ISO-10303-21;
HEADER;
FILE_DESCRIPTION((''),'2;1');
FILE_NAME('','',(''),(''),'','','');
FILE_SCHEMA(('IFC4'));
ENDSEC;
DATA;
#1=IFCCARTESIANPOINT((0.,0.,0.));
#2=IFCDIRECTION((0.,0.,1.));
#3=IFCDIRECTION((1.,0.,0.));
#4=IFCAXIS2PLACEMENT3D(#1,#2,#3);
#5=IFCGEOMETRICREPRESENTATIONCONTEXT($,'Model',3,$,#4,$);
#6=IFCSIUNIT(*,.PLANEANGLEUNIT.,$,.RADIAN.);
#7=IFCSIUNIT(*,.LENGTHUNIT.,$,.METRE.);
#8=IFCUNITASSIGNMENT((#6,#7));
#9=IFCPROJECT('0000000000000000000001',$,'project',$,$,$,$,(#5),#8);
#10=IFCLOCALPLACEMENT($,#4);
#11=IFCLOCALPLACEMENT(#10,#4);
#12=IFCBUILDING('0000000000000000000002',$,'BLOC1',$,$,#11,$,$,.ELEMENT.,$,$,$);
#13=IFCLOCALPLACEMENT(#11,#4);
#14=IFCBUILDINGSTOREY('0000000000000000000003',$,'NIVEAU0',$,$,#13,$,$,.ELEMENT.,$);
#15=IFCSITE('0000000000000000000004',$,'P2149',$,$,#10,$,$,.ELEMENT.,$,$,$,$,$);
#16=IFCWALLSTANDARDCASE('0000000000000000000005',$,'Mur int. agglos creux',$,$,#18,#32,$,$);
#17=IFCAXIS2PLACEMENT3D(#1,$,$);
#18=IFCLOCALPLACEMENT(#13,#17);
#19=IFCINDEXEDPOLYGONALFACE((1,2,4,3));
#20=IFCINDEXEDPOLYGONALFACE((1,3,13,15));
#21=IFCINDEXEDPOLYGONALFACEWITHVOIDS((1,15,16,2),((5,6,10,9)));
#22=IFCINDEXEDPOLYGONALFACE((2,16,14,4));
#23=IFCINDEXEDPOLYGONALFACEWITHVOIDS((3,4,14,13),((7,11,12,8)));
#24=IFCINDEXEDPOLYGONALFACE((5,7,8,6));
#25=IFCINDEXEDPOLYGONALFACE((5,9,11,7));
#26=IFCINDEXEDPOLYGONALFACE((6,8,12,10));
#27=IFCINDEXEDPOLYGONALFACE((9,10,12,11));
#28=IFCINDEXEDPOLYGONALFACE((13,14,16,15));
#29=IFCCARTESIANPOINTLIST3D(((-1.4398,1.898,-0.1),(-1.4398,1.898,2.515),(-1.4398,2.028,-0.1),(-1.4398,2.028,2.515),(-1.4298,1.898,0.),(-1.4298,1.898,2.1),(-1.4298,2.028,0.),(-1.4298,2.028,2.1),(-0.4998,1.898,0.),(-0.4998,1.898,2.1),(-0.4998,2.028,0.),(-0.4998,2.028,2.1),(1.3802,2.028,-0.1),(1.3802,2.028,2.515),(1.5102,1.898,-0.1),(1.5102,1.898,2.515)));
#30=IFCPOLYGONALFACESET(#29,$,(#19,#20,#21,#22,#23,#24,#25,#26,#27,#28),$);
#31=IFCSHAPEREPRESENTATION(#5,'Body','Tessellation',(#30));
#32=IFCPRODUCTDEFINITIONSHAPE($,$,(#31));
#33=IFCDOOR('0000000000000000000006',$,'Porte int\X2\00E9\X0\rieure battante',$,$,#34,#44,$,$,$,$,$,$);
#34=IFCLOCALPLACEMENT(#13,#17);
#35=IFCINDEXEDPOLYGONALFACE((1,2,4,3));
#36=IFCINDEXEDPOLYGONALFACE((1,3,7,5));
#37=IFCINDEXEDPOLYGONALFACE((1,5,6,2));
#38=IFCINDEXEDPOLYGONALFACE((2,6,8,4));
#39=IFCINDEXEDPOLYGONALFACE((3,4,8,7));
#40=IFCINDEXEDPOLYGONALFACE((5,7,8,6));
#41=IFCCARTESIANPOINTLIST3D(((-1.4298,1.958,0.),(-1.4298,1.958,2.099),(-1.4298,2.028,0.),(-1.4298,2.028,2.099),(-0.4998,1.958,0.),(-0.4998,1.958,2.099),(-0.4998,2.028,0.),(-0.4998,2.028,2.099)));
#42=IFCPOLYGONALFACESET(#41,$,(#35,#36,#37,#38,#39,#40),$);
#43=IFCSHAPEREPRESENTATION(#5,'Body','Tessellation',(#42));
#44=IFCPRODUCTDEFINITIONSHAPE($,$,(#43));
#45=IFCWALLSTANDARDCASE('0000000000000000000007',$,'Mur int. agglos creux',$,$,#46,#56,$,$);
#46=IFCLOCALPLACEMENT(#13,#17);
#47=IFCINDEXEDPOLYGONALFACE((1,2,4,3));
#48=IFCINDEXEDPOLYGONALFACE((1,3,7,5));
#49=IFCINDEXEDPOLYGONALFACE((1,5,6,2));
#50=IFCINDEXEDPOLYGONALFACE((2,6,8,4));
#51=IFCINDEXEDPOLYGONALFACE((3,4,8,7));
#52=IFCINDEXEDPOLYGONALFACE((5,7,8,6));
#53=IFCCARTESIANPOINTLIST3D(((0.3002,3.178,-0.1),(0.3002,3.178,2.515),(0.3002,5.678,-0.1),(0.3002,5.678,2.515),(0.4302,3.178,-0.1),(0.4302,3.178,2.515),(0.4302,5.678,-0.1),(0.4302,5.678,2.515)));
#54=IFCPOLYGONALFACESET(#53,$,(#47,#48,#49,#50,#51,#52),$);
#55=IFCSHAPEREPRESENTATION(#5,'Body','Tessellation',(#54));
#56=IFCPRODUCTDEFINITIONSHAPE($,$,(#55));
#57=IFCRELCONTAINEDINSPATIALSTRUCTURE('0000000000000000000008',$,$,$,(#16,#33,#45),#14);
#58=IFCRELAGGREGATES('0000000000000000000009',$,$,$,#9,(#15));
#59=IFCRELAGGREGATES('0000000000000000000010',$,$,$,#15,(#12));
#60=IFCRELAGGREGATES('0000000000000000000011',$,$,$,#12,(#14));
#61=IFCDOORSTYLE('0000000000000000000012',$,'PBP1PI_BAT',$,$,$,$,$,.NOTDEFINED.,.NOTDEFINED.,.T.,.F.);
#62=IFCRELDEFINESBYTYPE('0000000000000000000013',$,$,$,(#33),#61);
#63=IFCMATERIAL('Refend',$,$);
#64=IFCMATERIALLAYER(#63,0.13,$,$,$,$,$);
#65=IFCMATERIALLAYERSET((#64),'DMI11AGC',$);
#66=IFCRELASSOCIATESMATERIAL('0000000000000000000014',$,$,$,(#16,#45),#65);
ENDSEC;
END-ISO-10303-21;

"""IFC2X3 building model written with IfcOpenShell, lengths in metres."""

from ifc_helpers import new_model, si_unit, point, frame, frame_2d, origin_with_axes, place, context, project, spatial, line_curve, trimmed, segment, composite_curve, rectangle, outline, extrude, material, layer, layer_set, layer_usage, type_object, element, fill, save


model = new_model("IFC2X3")

# Units and contexts
model_context = context("Model", 3, world=origin_with_axes())
ifc_project = project(units=[si_unit("PLANEANGLEUNIT", "RADIAN"), si_unit("LENGTHUNIT", "METRE")], contexts=[model_context])

# Site, building, storey
site_placement = place(None, origin_with_axes())
site = spatial("IfcSite", under=ifc_project, at=site_placement, Name="P2149", CompositionType="ELEMENT")
building_placement = place(site_placement, origin_with_axes())
building = spatial("IfcBuilding", under=site, at=building_placement, Name="BLOC1", CompositionType="ELEMENT")
storey_placement = place(building_placement, origin_with_axes())
storey = spatial("IfcBuildingStorey", under=building, at=storey_placement, Name="NIVEAU0", CompositionType="ELEMENT")

# Wall, opening, door
ifc_material_1 = material(Name="Refend")
ifc_layer_1 = layer(ifc_material_1, 0.13)
ifc_layer_set_1 = layer_set([ifc_layer_1], Name="DMI11AGC")
ifc_layer_usage_1 = layer_usage(ifc_layer_set_1, "AXIS2", "POSITIVE", 0.0)
wall_1_placement = place(storey_placement, frame((1.3802, 2.028, -0.1), z_axis=(0.0, 0.0, 1.0), x_axis=(-1.0, 0.0, 0.0)))
wall_1 = element("IfcWallStandardCase", 1, at=wall_1_placement, inside=storey, material=ifc_layer_usage_1, Name="Mur int. agglos creux", context=model_context, shape_type="SweptSolid", body=[
    extrude(outline(composite_curve([segment(trimmed(line_curve((0.0, 0.0), (1.0, 0.0), 2.82), [point((0.0, 0.0))], [point((2.82, 0.0))], True, "CARTESIAN"), True, "CONTINUOUS"), segment(trimmed(line_curve((2.82, 0.0), (0.0, 1.0), 0.13), [point((2.82, 0.0))], [point((2.82, 0.13))], True, "CARTESIAN"), True, "CONTINUOUS"), segment(trimmed(line_curve((2.82, 0.13), (-1.0, 0.0), 2.95), [point((2.82, 0.13))], [point((-0.13, 0.13))], True, "CARTESIAN"), True, "CONTINUOUS"), segment(trimmed(line_curve((-0.13, 0.13), (0.707107, -0.707107), 0.183848), [point((-0.13, 0.13))], [point((0.0, 0.0))], True, "CARTESIAN"), True, "CONTINUOUS")], self_intersect=False)), origin_with_axes(), (0.0, 0.0, 1.0), 2.615),
])
opening_1_placement = place(wall_1_placement, frame((1.88, 0.0, 0.1), z_axis=(0.0, -1.0, 0.0), x_axis=(1.0, 0.0, 0.0)))
opening_1 = element("IfcOpeningElement", 2, at=opening_1_placement, cuts=wall_1, context=model_context, shape_type="SweptSolid", body=[
    extrude(rectangle(XDim=0.93, YDim=2.1, at=frame_2d((0.465, 1.05), x_axis=(1.0, 0.0))), origin_with_axes(), (0.0, 0.0, -1.0), 0.13),
])
door_style_1 = type_object("IfcDoorStyle", Name="PBP1PI_BAT", ConstructionType="NOTDEFINED", OperationType="NOTDEFINED", ParameterTakesPrecedence=True, Sizeable=False)
door_1_placement = place(opening_1_placement, origin_with_axes())
door_1 = element("IfcDoor", 3, at=door_1_placement, inside=storey, type_object=door_style_1, Name="Porte intérieure battante", context=model_context, shape_type="SweptSolid", body=[
    extrude(rectangle(XDim=0.93, YDim=2.099, at=frame_2d((0.465, 1.0495), x_axis=(1.0, 0.0))), origin_with_axes(), (0.0, 0.0, -1.0), 0.07),
])
fill(opening_1, door_1)

# Wall
wall_2_placement = place(storey_placement, frame((0.3002, 5.678, -0.1), z_axis=(0.0, 0.0, 1.0), x_axis=(0.0, -1.0, 0.0)))
element("IfcWallStandardCase", 4, at=wall_2_placement, inside=storey, material=ifc_layer_usage_1, Name="Mur int. agglos creux", context=model_context, shape_type="SweptSolid", body=[
    extrude(outline(composite_curve([segment(trimmed(line_curve((0.0, 0.0), (1.0, 0.0), 2.5), [point((0.0, 0.0))], [point((2.5, 0.0))], True, "CARTESIAN"), True, "CONTINUOUS"), segment(trimmed(line_curve((2.5, 0.0), (0.0, 1.0), 0.13), [point((2.5, 0.0))], [point((2.5, 0.13))], True, "CARTESIAN"), True, "CONTINUOUS"), segment(trimmed(line_curve((2.5, 0.13), (-1.0, 0.0), 2.5), [point((2.5, 0.13))], [point((0.0, 0.13))], True, "CARTESIAN"), True, "CONTINUOUS"), segment(trimmed(line_curve((0.0, 0.13), (0.0, -1.0), 0.13), [point((0.0, 0.13))], [point((0.0, 0.0))], True, "CARTESIAN"), True, "CONTINUOUS")], self_intersect=False)), origin_with_axes(), (0.0, 0.0, 1.0), 2.615),
])

save(model, "model.ifc")
